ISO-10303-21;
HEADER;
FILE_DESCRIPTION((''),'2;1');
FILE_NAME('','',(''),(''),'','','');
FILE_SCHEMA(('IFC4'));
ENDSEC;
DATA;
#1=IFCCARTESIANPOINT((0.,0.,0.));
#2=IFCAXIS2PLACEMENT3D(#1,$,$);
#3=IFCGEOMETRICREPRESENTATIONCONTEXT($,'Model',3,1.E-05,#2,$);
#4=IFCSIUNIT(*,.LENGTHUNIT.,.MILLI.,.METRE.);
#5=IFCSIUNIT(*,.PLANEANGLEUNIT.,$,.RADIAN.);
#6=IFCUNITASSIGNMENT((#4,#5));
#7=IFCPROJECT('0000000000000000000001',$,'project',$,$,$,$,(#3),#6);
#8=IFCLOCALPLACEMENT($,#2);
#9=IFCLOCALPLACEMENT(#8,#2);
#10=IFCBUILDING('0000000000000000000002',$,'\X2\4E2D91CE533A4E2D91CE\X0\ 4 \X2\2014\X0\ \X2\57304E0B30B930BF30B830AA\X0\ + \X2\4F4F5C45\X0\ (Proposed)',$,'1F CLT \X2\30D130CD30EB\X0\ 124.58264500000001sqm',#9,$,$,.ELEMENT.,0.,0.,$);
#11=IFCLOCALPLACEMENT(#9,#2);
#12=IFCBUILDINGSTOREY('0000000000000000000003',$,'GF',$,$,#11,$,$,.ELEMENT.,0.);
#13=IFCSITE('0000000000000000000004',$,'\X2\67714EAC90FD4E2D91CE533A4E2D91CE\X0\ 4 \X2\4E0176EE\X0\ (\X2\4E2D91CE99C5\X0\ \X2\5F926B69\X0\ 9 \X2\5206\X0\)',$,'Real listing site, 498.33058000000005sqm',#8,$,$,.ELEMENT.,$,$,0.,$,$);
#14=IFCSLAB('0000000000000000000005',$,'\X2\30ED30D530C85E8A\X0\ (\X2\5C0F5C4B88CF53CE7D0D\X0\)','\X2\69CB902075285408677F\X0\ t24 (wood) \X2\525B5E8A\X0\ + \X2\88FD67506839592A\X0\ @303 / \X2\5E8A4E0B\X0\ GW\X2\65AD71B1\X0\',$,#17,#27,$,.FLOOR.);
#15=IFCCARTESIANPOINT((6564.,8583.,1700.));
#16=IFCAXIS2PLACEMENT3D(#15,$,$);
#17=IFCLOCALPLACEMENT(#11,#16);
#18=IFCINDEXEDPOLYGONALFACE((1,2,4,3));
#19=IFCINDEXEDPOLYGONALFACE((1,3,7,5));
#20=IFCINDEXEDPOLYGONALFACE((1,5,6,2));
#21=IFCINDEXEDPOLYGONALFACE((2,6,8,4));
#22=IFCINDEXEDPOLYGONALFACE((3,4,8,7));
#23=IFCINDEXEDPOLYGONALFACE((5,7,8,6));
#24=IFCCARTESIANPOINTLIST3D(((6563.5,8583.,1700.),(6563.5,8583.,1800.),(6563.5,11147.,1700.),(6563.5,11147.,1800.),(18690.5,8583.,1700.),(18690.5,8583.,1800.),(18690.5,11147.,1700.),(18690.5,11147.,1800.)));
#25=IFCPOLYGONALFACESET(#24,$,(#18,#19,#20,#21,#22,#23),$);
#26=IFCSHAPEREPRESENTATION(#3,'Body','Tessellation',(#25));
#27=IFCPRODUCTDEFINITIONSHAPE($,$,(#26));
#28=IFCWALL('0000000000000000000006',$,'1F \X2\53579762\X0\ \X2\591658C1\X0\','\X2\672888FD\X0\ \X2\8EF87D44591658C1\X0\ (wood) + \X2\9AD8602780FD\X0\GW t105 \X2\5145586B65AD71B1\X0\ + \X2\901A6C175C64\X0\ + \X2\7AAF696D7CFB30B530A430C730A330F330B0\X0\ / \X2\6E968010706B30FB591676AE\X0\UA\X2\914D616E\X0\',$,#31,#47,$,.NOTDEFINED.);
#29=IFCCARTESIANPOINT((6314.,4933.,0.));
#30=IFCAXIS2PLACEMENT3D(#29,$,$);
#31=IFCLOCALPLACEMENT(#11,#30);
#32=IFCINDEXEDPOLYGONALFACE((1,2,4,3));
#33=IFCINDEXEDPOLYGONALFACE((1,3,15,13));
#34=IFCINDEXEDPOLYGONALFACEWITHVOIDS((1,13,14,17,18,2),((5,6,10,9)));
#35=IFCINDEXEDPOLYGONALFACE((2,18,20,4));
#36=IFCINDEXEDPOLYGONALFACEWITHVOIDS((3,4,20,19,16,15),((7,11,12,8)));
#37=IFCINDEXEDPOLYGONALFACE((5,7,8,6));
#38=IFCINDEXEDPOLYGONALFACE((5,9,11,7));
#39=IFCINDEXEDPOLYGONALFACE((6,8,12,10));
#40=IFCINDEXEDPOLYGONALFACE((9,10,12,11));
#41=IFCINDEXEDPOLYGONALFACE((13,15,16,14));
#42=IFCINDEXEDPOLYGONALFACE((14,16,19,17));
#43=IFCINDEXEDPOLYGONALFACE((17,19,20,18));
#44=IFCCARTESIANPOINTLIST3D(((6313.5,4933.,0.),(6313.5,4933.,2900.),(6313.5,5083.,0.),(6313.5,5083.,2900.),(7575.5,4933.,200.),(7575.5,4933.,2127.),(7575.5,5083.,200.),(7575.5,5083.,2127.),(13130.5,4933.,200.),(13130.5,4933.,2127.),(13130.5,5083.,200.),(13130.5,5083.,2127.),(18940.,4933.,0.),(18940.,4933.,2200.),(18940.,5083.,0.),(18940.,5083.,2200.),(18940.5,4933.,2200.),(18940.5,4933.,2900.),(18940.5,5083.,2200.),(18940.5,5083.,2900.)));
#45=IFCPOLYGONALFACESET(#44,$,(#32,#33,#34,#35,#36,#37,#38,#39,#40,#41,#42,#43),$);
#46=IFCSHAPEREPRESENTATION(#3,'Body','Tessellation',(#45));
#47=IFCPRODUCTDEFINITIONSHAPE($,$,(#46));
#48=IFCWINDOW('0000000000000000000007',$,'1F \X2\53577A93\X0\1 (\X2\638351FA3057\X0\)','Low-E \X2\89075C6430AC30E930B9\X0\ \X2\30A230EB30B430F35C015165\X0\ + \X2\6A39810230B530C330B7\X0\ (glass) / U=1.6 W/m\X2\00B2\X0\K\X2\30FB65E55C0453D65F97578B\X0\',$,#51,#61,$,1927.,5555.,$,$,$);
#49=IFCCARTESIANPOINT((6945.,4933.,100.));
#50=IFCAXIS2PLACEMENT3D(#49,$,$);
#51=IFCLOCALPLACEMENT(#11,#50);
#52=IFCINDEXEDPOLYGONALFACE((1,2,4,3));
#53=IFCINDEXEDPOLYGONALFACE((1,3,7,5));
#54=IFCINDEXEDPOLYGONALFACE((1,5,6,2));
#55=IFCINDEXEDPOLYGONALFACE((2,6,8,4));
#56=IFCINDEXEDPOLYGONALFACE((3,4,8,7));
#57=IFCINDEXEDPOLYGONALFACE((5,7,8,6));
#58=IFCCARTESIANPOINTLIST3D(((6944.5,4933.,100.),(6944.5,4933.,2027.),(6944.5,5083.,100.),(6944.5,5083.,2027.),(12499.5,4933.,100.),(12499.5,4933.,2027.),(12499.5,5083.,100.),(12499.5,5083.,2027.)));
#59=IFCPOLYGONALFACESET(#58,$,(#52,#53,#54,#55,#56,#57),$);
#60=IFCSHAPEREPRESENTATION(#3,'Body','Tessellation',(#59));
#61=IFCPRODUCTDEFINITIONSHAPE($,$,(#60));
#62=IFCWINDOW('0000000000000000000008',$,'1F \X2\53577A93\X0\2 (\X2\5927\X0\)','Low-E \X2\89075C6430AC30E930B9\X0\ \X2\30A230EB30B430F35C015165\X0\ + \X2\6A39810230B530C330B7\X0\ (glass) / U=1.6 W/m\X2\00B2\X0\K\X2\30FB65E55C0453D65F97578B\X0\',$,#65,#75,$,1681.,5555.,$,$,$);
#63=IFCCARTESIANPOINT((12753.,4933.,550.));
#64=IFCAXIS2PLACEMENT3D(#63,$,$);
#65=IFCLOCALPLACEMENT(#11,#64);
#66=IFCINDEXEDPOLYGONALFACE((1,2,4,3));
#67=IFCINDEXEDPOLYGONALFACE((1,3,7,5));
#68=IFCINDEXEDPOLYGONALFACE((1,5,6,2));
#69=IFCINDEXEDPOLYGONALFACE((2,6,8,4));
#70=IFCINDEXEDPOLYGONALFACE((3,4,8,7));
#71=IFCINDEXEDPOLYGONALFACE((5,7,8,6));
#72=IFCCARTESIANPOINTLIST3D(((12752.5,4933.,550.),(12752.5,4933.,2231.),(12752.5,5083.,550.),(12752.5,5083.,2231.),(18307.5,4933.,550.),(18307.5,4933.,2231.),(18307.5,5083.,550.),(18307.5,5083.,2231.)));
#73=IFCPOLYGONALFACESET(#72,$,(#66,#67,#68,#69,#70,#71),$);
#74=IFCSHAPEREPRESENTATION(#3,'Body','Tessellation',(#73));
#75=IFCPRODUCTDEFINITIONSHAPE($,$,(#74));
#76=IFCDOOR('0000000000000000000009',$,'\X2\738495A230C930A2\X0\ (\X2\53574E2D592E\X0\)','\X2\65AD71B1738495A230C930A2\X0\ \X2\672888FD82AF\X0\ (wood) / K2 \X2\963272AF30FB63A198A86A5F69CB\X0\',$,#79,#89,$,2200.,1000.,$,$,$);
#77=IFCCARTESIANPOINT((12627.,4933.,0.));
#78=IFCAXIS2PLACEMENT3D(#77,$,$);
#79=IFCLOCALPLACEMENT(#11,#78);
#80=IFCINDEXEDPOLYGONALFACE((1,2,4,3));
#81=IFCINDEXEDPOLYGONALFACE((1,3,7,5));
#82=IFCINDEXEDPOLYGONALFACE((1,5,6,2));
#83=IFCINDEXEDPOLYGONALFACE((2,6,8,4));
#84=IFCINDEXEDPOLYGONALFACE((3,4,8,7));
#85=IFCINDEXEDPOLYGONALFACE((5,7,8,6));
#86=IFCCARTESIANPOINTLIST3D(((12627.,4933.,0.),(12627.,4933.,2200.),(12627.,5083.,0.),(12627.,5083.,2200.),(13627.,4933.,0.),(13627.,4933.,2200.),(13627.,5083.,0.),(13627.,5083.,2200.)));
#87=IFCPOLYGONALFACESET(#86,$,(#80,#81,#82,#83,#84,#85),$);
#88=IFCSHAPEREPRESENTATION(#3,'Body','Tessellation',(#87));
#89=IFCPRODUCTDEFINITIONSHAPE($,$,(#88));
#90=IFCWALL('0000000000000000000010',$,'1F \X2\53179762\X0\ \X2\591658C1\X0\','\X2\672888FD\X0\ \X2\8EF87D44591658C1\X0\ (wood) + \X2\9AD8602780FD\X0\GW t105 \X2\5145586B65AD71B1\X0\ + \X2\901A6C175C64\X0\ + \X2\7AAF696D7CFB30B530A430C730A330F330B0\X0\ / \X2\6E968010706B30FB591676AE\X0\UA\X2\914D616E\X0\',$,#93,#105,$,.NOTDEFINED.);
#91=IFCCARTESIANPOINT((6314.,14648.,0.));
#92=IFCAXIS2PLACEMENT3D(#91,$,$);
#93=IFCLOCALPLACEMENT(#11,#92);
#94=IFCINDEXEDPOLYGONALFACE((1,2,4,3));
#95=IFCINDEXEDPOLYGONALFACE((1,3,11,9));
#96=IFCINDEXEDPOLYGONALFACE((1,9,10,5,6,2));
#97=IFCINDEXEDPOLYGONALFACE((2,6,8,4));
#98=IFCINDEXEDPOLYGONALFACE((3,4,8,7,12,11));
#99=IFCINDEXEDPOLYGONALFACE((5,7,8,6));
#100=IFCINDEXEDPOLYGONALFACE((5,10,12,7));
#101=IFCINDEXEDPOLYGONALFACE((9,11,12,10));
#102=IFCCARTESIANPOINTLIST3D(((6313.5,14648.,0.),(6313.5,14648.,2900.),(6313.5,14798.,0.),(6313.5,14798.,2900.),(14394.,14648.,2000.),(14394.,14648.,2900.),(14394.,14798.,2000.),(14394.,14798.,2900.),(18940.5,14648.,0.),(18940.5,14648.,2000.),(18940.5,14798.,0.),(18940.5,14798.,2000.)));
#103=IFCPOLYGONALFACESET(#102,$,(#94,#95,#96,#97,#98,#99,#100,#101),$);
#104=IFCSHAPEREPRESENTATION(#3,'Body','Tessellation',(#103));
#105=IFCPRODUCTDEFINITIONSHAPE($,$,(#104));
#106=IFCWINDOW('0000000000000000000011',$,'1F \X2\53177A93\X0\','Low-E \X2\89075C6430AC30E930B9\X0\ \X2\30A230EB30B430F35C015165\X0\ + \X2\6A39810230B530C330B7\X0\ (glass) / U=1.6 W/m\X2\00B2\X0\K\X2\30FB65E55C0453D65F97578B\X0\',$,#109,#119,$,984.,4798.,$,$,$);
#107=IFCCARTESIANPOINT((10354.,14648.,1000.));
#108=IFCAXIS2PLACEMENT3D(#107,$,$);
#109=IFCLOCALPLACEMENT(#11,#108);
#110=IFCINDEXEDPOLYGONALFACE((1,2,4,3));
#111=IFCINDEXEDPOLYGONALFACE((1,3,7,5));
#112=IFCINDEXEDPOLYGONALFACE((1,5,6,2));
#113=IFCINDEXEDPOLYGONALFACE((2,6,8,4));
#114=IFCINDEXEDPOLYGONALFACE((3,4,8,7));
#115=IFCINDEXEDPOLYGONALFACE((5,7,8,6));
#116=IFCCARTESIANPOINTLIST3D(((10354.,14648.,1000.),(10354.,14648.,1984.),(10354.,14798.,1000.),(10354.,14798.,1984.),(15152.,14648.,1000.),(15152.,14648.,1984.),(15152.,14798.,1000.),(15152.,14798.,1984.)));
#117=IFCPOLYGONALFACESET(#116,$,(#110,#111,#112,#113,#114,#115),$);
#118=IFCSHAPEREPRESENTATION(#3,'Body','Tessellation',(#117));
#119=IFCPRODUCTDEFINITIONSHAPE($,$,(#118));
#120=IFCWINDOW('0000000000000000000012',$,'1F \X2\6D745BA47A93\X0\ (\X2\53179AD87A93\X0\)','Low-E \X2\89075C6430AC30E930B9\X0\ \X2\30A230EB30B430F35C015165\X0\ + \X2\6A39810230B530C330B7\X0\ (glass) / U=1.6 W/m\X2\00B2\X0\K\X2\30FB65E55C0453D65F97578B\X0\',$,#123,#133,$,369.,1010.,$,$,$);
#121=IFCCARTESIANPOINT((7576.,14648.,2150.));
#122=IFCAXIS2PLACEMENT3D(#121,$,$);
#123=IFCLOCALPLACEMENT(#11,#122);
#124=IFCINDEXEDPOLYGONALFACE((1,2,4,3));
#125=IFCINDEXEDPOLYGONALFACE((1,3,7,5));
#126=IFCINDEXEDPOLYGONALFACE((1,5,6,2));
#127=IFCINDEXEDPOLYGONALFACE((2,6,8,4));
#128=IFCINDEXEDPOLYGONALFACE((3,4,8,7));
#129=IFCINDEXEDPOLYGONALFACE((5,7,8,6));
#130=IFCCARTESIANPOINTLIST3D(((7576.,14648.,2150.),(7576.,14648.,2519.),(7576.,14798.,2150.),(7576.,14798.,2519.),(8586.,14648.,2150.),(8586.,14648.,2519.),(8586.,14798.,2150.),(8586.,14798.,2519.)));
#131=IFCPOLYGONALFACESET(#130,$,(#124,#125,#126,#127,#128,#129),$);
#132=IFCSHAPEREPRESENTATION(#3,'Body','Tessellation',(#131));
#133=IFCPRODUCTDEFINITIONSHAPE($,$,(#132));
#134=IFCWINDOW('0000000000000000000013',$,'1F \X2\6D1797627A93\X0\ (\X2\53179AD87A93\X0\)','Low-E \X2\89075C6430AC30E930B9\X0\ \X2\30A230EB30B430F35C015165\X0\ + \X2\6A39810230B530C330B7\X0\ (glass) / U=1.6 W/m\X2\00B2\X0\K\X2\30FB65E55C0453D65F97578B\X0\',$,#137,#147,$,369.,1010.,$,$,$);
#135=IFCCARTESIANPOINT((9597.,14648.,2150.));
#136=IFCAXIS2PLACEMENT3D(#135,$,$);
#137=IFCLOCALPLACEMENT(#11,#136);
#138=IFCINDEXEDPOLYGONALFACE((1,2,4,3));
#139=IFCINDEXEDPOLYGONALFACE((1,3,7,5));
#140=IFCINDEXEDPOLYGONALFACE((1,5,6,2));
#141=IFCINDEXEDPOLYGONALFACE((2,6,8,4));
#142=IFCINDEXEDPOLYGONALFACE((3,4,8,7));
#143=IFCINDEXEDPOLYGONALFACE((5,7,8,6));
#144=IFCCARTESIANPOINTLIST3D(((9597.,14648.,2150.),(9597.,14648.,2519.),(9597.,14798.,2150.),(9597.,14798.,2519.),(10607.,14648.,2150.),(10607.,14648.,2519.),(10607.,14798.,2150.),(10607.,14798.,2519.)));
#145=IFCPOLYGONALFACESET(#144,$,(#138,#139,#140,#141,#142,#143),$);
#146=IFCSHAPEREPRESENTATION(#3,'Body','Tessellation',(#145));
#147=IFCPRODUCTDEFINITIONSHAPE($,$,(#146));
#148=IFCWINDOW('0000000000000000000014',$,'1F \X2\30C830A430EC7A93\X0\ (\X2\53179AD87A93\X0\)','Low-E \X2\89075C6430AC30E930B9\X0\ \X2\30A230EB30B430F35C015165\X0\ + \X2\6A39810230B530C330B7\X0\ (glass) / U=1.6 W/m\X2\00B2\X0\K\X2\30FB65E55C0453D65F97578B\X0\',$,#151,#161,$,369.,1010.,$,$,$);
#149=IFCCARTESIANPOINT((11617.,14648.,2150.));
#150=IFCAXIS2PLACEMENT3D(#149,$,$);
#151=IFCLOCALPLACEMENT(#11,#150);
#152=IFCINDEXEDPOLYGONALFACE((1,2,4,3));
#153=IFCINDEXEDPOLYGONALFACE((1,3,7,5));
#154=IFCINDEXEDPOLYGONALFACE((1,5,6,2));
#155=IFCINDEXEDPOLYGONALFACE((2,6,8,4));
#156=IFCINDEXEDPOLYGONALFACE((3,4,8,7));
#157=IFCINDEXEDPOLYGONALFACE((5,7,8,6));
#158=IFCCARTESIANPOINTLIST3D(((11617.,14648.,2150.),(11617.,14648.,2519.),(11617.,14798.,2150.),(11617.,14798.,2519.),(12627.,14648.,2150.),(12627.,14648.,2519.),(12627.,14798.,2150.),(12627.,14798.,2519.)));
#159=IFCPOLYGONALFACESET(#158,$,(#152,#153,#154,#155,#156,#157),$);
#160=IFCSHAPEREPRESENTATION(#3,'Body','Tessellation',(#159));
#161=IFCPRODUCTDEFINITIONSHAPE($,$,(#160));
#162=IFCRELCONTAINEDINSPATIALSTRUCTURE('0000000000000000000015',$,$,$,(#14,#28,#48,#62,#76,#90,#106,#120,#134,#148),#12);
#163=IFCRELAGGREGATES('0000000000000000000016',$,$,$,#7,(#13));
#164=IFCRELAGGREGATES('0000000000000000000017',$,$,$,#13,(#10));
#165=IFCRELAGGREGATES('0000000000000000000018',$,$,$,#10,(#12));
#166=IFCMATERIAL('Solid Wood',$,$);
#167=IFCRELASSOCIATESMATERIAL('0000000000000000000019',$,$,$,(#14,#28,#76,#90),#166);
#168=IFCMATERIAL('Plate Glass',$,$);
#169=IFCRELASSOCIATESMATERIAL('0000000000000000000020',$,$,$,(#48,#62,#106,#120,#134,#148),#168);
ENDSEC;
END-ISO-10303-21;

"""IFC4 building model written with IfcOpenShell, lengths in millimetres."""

from ifc_helpers import new_model, si_unit, frame, frame_2d, origin, place, context, project, spatial, rectangle, extrude, material, element, fill, save


model = new_model("IFC4")

# Units and contexts
model_context = context("Model", 3, precision=1e-05, world=origin())
ifc_project = project(units=[si_unit("LENGTHUNIT", "METRE", prefix="MILLI"), si_unit("PLANEANGLEUNIT", "RADIAN")], contexts=[model_context])

# Site, building, storey
site_placement = place(None, origin())
site = spatial("IfcSite", under=ifc_project, at=site_placement, Name="東京都中野区中野 4 丁目 (中野駅 徒歩 9 分)", ObjectType="Real listing site, 498.33058000000005sqm", CompositionType="ELEMENT", RefElevation=0.0)
building_placement = place(site_placement, origin())
building = spatial("IfcBuilding", under=site, at=building_placement, Name="中野区中野 4 — 地下スタジオ + 住居 (Proposed)", ObjectType="1F CLT パネル 124.58264500000001sqm", CompositionType="ELEMENT", ElevationOfRefHeight=0.0, ElevationOfTerrain=0.0)
storey_placement = place(building_placement, origin())
storey = spatial("IfcBuildingStorey", under=building, at=storey_placement, Name="GF", CompositionType="ELEMENT", Elevation=0.0)

# Slab
ifc_material_1 = material(Name="Solid Wood")
slab_1_placement = place(storey_placement, frame((6564.0, 8583.0, 1700.0)))
element("IfcSlab", 1, at=slab_1_placement, inside=storey, material=ifc_material_1, Name="ロフト床 (小屋裏収納)", Description="構造用合板 t24 (wood) 剛床 + 製材根太 @303 / 床下 GW断熱", PredefinedType="FLOOR", context=model_context, shape_type="SweptSolid", body=[
    extrude(rectangle(XDim=12127.0, YDim=2564.0, at=frame_2d((6063.0, 1282.0))), frame((6564.0, 8583.0, 1700.0)), (0.0, 0.0, 1.0), 100.0),
])

# Wall, openings, windows, door
wall_1_placement = place(storey_placement, frame((6314.0, 4933.0, 0.0)))
wall_1 = element("IfcWall", 2, at=wall_1_placement, inside=storey, material=ifc_material_1, Name="1F 南面 外壁", Description="木製 軸組外壁 (wood) + 高性能GW t105 充填断熱 + 通気層 + 窯業系サイディング / 準耐火・外皮UA配慮", PredefinedType="NOTDEFINED", context=model_context, shape_type="SweptSolid", body=[
    extrude(rectangle(XDim=12627.0, YDim=150.0, at=frame_2d((6313.0, 75.0))), frame((6314.0, 4933.0, 0.0)), (0.0, 0.0, 1.0), 2900.0),
])
opening_1_placement = place(storey_placement, frame((6945.0, 4933.0, 100.0)))
opening_1 = element("IfcOpeningElement", 3, at=opening_1_placement, cuts=wall_1, PredefinedType="NOTDEFINED", context=model_context, shape_type="SweptSolid", body=[
    extrude(rectangle(XDim=5555.0, YDim=150.0, at=frame_2d((2777.0, 75.0))), frame((6945.0, 4933.0, 100.0)), (0.0, 0.0, 1.0), 1927.0),
])
opening_2_placement = place(storey_placement, frame((12753.0, 4933.0, 550.0)))
opening_2 = element("IfcOpeningElement", 4, at=opening_2_placement, cuts=wall_1, PredefinedType="NOTDEFINED", context=model_context, shape_type="SweptSolid", body=[
    extrude(rectangle(XDim=5555.0, YDim=150.0, at=frame_2d((2777.0, 75.0))), frame((12753.0, 4933.0, 550.0)), (0.0, 0.0, 1.0), 1681.0),
])
opening_3_placement = place(storey_placement, frame((12627.0, 4933.0, 0.0)))
opening_3 = element("IfcOpeningElement", 5, at=opening_3_placement, cuts=wall_1, PredefinedType="NOTDEFINED", context=model_context, shape_type="SweptSolid", body=[
    extrude(rectangle(XDim=1000.0, YDim=150.0, at=frame_2d((500.0, 75.0))), frame((12627.0, 4933.0, 0.0)), (0.0, 0.0, 1.0), 2200.0),
])
ifc_material_2 = material(Name="Plate Glass")
window_1_placement = place(storey_placement, frame((6945.0, 4933.0, 100.0)))
window_1 = element("IfcWindow", 6, at=window_1_placement, inside=storey, material=ifc_material_2, Name="1F 南窓1 (掃出し)", Description="Low-E 複層ガラス アルゴン封入 + 樹脂サッシ (glass) / U=1.6 W/m²K・日射取得型", OverallHeight=1927.0, OverallWidth=5555.0, context=model_context, shape_type="SweptSolid", body=[
    extrude(rectangle(XDim=5555.0, YDim=150.0, at=frame_2d((2777.0, 75.0))), frame((6945.0, 4933.0, 100.0)), (0.0, 0.0, 1.0), 1927.0),
])
fill(opening_1, window_1)
window_2_placement = place(storey_placement, frame((12753.0, 4933.0, 550.0)))
window_2 = element("IfcWindow", 7, at=window_2_placement, inside=storey, material=ifc_material_2, Name="1F 南窓2 (大)", Description="Low-E 複層ガラス アルゴン封入 + 樹脂サッシ (glass) / U=1.6 W/m²K・日射取得型", OverallHeight=1681.0, OverallWidth=5555.0, context=model_context, shape_type="SweptSolid", body=[
    extrude(rectangle(XDim=5555.0, YDim=150.0, at=frame_2d((2777.0, 75.0))), frame((12753.0, 4933.0, 550.0)), (0.0, 0.0, 1.0), 1681.0),
])
fill(opening_2, window_2)
door_1_placement = place(storey_placement, frame((12627.0, 4933.0, 0.0)))
door_1 = element("IfcDoor", 8, at=door_1_placement, inside=storey, material=ifc_material_1, Name="玄関ドア (南中央)", Description="断熱玄関ドア 木製芯 (wood) / K2 防犯・採風機構", OverallHeight=2200.0, OverallWidth=1000.0, context=model_context, shape_type="SweptSolid", body=[
    extrude(rectangle(XDim=1000.0, YDim=150.0, at=frame_2d((500.0, 75.0))), frame((12627.0, 4933.0, 0.0)), (0.0, 0.0, 1.0), 2200.0),
])
fill(opening_3, door_1)

# Wall, openings, windows
wall_2_placement = place(storey_placement, frame((6314.0, 14648.0, 0.0)))
wall_2 = element("IfcWall", 9, at=wall_2_placement, inside=storey, material=ifc_material_1, Name="1F 北面 外壁", Description="木製 軸組外壁 (wood) + 高性能GW t105 充填断熱 + 通気層 + 窯業系サイディング / 準耐火・外皮UA配慮", PredefinedType="NOTDEFINED", context=model_context, shape_type="SweptSolid", body=[
    extrude(rectangle(XDim=12627.0, YDim=150.0, at=frame_2d((6313.0, 75.0))), frame((6314.0, 14648.0, 0.0)), (0.0, 0.0, 1.0), 2900.0),
])
opening_4_placement = place(storey_placement, frame((10354.0, 14648.0, 1000.0)))
opening_4 = element("IfcOpeningElement", 10, at=opening_4_placement, cuts=wall_2, PredefinedType="NOTDEFINED", context=model_context, shape_type="SweptSolid", body=[
    extrude(rectangle(XDim=4798.0, YDim=150.0, at=frame_2d((2399.0, 75.0))), frame((10354.0, 14648.0, 1000.0)), (0.0, 0.0, 1.0), 984.0),
])
opening_5_placement = place(storey_placement, frame((7576.0, 14648.0, 2150.0)))
opening_5 = element("IfcOpeningElement", 11, at=opening_5_placement, cuts=wall_2, PredefinedType="NOTDEFINED", context=model_context, shape_type="SweptSolid", body=[
    extrude(rectangle(XDim=1010.0, YDim=150.0, at=frame_2d((505.0, 75.0))), frame((7576.0, 14648.0, 2150.0)), (0.0, 0.0, 1.0), 369.0),
])
opening_6_placement = place(storey_placement, frame((9597.0, 14648.0, 2150.0)))
opening_6 = element("IfcOpeningElement", 12, at=opening_6_placement, cuts=wall_2, PredefinedType="NOTDEFINED", context=model_context, shape_type="SweptSolid", body=[
    extrude(rectangle(XDim=1010.0, YDim=150.0, at=frame_2d((505.0, 75.0))), frame((9597.0, 14648.0, 2150.0)), (0.0, 0.0, 1.0), 369.0),
])
opening_7_placement = place(storey_placement, frame((11617.0, 14648.0, 2150.0)))
opening_7 = element("IfcOpeningElement", 13, at=opening_7_placement, cuts=wall_2, PredefinedType="NOTDEFINED", context=model_context, shape_type="SweptSolid", body=[
    extrude(rectangle(XDim=1010.0, YDim=150.0, at=frame_2d((505.0, 75.0))), frame((11617.0, 14648.0, 2150.0)), (0.0, 0.0, 1.0), 369.0),
])
window_3_placement = place(storey_placement, frame((10354.0, 14648.0, 1000.0)))
window_3 = element("IfcWindow", 14, at=window_3_placement, inside=storey, material=ifc_material_2, Name="1F 北窓", Description="Low-E 複層ガラス アルゴン封入 + 樹脂サッシ (glass) / U=1.6 W/m²K・日射取得型", OverallHeight=984.0, OverallWidth=4798.0, context=model_context, shape_type="SweptSolid", body=[
    extrude(rectangle(XDim=4798.0, YDim=150.0, at=frame_2d((2399.0, 75.0))), frame((10354.0, 14648.0, 1000.0)), (0.0, 0.0, 1.0), 984.0),
])
fill(opening_4, window_3)
window_4_placement = place(storey_placement, frame((7576.0, 14648.0, 2150.0)))
window_4 = element("IfcWindow", 15, at=window_4_placement, inside=storey, material=ifc_material_2, Name="1F 浴室窓 (北高窓)", Description="Low-E 複層ガラス アルゴン封入 + 樹脂サッシ (glass) / U=1.6 W/m²K・日射取得型", OverallHeight=369.0, OverallWidth=1010.0, context=model_context, shape_type="SweptSolid", body=[
    extrude(rectangle(XDim=1010.0, YDim=150.0, at=frame_2d((505.0, 75.0))), frame((7576.0, 14648.0, 2150.0)), (0.0, 0.0, 1.0), 369.0),
])
fill(opening_5, window_4)
window_5_placement = place(storey_placement, frame((9597.0, 14648.0, 2150.0)))
window_5 = element("IfcWindow", 16, at=window_5_placement, inside=storey, material=ifc_material_2, Name="1F 洗面窓 (北高窓)", Description="Low-E 複層ガラス アルゴン封入 + 樹脂サッシ (glass) / U=1.6 W/m²K・日射取得型", OverallHeight=369.0, OverallWidth=1010.0, context=model_context, shape_type="SweptSolid", body=[
    extrude(rectangle(XDim=1010.0, YDim=150.0, at=frame_2d((505.0, 75.0))), frame((9597.0, 14648.0, 2150.0)), (0.0, 0.0, 1.0), 369.0),
])
fill(opening_6, window_5)
window_6_placement = place(storey_placement, frame((11617.0, 14648.0, 2150.0)))
window_6 = element("IfcWindow", 17, at=window_6_placement, inside=storey, material=ifc_material_2, Name="1F トイレ窓 (北高窓)", Description="Low-E 複層ガラス アルゴン封入 + 樹脂サッシ (glass) / U=1.6 W/m²K・日射取得型", OverallHeight=369.0, OverallWidth=1010.0, context=model_context, shape_type="SweptSolid", body=[
    extrude(rectangle(XDim=1010.0, YDim=150.0, at=frame_2d((505.0, 75.0))), frame((11617.0, 14648.0, 2150.0)), (0.0, 0.0, 1.0), 369.0),
])
fill(opening_7, window_6)

save(model, "model.ifc")
